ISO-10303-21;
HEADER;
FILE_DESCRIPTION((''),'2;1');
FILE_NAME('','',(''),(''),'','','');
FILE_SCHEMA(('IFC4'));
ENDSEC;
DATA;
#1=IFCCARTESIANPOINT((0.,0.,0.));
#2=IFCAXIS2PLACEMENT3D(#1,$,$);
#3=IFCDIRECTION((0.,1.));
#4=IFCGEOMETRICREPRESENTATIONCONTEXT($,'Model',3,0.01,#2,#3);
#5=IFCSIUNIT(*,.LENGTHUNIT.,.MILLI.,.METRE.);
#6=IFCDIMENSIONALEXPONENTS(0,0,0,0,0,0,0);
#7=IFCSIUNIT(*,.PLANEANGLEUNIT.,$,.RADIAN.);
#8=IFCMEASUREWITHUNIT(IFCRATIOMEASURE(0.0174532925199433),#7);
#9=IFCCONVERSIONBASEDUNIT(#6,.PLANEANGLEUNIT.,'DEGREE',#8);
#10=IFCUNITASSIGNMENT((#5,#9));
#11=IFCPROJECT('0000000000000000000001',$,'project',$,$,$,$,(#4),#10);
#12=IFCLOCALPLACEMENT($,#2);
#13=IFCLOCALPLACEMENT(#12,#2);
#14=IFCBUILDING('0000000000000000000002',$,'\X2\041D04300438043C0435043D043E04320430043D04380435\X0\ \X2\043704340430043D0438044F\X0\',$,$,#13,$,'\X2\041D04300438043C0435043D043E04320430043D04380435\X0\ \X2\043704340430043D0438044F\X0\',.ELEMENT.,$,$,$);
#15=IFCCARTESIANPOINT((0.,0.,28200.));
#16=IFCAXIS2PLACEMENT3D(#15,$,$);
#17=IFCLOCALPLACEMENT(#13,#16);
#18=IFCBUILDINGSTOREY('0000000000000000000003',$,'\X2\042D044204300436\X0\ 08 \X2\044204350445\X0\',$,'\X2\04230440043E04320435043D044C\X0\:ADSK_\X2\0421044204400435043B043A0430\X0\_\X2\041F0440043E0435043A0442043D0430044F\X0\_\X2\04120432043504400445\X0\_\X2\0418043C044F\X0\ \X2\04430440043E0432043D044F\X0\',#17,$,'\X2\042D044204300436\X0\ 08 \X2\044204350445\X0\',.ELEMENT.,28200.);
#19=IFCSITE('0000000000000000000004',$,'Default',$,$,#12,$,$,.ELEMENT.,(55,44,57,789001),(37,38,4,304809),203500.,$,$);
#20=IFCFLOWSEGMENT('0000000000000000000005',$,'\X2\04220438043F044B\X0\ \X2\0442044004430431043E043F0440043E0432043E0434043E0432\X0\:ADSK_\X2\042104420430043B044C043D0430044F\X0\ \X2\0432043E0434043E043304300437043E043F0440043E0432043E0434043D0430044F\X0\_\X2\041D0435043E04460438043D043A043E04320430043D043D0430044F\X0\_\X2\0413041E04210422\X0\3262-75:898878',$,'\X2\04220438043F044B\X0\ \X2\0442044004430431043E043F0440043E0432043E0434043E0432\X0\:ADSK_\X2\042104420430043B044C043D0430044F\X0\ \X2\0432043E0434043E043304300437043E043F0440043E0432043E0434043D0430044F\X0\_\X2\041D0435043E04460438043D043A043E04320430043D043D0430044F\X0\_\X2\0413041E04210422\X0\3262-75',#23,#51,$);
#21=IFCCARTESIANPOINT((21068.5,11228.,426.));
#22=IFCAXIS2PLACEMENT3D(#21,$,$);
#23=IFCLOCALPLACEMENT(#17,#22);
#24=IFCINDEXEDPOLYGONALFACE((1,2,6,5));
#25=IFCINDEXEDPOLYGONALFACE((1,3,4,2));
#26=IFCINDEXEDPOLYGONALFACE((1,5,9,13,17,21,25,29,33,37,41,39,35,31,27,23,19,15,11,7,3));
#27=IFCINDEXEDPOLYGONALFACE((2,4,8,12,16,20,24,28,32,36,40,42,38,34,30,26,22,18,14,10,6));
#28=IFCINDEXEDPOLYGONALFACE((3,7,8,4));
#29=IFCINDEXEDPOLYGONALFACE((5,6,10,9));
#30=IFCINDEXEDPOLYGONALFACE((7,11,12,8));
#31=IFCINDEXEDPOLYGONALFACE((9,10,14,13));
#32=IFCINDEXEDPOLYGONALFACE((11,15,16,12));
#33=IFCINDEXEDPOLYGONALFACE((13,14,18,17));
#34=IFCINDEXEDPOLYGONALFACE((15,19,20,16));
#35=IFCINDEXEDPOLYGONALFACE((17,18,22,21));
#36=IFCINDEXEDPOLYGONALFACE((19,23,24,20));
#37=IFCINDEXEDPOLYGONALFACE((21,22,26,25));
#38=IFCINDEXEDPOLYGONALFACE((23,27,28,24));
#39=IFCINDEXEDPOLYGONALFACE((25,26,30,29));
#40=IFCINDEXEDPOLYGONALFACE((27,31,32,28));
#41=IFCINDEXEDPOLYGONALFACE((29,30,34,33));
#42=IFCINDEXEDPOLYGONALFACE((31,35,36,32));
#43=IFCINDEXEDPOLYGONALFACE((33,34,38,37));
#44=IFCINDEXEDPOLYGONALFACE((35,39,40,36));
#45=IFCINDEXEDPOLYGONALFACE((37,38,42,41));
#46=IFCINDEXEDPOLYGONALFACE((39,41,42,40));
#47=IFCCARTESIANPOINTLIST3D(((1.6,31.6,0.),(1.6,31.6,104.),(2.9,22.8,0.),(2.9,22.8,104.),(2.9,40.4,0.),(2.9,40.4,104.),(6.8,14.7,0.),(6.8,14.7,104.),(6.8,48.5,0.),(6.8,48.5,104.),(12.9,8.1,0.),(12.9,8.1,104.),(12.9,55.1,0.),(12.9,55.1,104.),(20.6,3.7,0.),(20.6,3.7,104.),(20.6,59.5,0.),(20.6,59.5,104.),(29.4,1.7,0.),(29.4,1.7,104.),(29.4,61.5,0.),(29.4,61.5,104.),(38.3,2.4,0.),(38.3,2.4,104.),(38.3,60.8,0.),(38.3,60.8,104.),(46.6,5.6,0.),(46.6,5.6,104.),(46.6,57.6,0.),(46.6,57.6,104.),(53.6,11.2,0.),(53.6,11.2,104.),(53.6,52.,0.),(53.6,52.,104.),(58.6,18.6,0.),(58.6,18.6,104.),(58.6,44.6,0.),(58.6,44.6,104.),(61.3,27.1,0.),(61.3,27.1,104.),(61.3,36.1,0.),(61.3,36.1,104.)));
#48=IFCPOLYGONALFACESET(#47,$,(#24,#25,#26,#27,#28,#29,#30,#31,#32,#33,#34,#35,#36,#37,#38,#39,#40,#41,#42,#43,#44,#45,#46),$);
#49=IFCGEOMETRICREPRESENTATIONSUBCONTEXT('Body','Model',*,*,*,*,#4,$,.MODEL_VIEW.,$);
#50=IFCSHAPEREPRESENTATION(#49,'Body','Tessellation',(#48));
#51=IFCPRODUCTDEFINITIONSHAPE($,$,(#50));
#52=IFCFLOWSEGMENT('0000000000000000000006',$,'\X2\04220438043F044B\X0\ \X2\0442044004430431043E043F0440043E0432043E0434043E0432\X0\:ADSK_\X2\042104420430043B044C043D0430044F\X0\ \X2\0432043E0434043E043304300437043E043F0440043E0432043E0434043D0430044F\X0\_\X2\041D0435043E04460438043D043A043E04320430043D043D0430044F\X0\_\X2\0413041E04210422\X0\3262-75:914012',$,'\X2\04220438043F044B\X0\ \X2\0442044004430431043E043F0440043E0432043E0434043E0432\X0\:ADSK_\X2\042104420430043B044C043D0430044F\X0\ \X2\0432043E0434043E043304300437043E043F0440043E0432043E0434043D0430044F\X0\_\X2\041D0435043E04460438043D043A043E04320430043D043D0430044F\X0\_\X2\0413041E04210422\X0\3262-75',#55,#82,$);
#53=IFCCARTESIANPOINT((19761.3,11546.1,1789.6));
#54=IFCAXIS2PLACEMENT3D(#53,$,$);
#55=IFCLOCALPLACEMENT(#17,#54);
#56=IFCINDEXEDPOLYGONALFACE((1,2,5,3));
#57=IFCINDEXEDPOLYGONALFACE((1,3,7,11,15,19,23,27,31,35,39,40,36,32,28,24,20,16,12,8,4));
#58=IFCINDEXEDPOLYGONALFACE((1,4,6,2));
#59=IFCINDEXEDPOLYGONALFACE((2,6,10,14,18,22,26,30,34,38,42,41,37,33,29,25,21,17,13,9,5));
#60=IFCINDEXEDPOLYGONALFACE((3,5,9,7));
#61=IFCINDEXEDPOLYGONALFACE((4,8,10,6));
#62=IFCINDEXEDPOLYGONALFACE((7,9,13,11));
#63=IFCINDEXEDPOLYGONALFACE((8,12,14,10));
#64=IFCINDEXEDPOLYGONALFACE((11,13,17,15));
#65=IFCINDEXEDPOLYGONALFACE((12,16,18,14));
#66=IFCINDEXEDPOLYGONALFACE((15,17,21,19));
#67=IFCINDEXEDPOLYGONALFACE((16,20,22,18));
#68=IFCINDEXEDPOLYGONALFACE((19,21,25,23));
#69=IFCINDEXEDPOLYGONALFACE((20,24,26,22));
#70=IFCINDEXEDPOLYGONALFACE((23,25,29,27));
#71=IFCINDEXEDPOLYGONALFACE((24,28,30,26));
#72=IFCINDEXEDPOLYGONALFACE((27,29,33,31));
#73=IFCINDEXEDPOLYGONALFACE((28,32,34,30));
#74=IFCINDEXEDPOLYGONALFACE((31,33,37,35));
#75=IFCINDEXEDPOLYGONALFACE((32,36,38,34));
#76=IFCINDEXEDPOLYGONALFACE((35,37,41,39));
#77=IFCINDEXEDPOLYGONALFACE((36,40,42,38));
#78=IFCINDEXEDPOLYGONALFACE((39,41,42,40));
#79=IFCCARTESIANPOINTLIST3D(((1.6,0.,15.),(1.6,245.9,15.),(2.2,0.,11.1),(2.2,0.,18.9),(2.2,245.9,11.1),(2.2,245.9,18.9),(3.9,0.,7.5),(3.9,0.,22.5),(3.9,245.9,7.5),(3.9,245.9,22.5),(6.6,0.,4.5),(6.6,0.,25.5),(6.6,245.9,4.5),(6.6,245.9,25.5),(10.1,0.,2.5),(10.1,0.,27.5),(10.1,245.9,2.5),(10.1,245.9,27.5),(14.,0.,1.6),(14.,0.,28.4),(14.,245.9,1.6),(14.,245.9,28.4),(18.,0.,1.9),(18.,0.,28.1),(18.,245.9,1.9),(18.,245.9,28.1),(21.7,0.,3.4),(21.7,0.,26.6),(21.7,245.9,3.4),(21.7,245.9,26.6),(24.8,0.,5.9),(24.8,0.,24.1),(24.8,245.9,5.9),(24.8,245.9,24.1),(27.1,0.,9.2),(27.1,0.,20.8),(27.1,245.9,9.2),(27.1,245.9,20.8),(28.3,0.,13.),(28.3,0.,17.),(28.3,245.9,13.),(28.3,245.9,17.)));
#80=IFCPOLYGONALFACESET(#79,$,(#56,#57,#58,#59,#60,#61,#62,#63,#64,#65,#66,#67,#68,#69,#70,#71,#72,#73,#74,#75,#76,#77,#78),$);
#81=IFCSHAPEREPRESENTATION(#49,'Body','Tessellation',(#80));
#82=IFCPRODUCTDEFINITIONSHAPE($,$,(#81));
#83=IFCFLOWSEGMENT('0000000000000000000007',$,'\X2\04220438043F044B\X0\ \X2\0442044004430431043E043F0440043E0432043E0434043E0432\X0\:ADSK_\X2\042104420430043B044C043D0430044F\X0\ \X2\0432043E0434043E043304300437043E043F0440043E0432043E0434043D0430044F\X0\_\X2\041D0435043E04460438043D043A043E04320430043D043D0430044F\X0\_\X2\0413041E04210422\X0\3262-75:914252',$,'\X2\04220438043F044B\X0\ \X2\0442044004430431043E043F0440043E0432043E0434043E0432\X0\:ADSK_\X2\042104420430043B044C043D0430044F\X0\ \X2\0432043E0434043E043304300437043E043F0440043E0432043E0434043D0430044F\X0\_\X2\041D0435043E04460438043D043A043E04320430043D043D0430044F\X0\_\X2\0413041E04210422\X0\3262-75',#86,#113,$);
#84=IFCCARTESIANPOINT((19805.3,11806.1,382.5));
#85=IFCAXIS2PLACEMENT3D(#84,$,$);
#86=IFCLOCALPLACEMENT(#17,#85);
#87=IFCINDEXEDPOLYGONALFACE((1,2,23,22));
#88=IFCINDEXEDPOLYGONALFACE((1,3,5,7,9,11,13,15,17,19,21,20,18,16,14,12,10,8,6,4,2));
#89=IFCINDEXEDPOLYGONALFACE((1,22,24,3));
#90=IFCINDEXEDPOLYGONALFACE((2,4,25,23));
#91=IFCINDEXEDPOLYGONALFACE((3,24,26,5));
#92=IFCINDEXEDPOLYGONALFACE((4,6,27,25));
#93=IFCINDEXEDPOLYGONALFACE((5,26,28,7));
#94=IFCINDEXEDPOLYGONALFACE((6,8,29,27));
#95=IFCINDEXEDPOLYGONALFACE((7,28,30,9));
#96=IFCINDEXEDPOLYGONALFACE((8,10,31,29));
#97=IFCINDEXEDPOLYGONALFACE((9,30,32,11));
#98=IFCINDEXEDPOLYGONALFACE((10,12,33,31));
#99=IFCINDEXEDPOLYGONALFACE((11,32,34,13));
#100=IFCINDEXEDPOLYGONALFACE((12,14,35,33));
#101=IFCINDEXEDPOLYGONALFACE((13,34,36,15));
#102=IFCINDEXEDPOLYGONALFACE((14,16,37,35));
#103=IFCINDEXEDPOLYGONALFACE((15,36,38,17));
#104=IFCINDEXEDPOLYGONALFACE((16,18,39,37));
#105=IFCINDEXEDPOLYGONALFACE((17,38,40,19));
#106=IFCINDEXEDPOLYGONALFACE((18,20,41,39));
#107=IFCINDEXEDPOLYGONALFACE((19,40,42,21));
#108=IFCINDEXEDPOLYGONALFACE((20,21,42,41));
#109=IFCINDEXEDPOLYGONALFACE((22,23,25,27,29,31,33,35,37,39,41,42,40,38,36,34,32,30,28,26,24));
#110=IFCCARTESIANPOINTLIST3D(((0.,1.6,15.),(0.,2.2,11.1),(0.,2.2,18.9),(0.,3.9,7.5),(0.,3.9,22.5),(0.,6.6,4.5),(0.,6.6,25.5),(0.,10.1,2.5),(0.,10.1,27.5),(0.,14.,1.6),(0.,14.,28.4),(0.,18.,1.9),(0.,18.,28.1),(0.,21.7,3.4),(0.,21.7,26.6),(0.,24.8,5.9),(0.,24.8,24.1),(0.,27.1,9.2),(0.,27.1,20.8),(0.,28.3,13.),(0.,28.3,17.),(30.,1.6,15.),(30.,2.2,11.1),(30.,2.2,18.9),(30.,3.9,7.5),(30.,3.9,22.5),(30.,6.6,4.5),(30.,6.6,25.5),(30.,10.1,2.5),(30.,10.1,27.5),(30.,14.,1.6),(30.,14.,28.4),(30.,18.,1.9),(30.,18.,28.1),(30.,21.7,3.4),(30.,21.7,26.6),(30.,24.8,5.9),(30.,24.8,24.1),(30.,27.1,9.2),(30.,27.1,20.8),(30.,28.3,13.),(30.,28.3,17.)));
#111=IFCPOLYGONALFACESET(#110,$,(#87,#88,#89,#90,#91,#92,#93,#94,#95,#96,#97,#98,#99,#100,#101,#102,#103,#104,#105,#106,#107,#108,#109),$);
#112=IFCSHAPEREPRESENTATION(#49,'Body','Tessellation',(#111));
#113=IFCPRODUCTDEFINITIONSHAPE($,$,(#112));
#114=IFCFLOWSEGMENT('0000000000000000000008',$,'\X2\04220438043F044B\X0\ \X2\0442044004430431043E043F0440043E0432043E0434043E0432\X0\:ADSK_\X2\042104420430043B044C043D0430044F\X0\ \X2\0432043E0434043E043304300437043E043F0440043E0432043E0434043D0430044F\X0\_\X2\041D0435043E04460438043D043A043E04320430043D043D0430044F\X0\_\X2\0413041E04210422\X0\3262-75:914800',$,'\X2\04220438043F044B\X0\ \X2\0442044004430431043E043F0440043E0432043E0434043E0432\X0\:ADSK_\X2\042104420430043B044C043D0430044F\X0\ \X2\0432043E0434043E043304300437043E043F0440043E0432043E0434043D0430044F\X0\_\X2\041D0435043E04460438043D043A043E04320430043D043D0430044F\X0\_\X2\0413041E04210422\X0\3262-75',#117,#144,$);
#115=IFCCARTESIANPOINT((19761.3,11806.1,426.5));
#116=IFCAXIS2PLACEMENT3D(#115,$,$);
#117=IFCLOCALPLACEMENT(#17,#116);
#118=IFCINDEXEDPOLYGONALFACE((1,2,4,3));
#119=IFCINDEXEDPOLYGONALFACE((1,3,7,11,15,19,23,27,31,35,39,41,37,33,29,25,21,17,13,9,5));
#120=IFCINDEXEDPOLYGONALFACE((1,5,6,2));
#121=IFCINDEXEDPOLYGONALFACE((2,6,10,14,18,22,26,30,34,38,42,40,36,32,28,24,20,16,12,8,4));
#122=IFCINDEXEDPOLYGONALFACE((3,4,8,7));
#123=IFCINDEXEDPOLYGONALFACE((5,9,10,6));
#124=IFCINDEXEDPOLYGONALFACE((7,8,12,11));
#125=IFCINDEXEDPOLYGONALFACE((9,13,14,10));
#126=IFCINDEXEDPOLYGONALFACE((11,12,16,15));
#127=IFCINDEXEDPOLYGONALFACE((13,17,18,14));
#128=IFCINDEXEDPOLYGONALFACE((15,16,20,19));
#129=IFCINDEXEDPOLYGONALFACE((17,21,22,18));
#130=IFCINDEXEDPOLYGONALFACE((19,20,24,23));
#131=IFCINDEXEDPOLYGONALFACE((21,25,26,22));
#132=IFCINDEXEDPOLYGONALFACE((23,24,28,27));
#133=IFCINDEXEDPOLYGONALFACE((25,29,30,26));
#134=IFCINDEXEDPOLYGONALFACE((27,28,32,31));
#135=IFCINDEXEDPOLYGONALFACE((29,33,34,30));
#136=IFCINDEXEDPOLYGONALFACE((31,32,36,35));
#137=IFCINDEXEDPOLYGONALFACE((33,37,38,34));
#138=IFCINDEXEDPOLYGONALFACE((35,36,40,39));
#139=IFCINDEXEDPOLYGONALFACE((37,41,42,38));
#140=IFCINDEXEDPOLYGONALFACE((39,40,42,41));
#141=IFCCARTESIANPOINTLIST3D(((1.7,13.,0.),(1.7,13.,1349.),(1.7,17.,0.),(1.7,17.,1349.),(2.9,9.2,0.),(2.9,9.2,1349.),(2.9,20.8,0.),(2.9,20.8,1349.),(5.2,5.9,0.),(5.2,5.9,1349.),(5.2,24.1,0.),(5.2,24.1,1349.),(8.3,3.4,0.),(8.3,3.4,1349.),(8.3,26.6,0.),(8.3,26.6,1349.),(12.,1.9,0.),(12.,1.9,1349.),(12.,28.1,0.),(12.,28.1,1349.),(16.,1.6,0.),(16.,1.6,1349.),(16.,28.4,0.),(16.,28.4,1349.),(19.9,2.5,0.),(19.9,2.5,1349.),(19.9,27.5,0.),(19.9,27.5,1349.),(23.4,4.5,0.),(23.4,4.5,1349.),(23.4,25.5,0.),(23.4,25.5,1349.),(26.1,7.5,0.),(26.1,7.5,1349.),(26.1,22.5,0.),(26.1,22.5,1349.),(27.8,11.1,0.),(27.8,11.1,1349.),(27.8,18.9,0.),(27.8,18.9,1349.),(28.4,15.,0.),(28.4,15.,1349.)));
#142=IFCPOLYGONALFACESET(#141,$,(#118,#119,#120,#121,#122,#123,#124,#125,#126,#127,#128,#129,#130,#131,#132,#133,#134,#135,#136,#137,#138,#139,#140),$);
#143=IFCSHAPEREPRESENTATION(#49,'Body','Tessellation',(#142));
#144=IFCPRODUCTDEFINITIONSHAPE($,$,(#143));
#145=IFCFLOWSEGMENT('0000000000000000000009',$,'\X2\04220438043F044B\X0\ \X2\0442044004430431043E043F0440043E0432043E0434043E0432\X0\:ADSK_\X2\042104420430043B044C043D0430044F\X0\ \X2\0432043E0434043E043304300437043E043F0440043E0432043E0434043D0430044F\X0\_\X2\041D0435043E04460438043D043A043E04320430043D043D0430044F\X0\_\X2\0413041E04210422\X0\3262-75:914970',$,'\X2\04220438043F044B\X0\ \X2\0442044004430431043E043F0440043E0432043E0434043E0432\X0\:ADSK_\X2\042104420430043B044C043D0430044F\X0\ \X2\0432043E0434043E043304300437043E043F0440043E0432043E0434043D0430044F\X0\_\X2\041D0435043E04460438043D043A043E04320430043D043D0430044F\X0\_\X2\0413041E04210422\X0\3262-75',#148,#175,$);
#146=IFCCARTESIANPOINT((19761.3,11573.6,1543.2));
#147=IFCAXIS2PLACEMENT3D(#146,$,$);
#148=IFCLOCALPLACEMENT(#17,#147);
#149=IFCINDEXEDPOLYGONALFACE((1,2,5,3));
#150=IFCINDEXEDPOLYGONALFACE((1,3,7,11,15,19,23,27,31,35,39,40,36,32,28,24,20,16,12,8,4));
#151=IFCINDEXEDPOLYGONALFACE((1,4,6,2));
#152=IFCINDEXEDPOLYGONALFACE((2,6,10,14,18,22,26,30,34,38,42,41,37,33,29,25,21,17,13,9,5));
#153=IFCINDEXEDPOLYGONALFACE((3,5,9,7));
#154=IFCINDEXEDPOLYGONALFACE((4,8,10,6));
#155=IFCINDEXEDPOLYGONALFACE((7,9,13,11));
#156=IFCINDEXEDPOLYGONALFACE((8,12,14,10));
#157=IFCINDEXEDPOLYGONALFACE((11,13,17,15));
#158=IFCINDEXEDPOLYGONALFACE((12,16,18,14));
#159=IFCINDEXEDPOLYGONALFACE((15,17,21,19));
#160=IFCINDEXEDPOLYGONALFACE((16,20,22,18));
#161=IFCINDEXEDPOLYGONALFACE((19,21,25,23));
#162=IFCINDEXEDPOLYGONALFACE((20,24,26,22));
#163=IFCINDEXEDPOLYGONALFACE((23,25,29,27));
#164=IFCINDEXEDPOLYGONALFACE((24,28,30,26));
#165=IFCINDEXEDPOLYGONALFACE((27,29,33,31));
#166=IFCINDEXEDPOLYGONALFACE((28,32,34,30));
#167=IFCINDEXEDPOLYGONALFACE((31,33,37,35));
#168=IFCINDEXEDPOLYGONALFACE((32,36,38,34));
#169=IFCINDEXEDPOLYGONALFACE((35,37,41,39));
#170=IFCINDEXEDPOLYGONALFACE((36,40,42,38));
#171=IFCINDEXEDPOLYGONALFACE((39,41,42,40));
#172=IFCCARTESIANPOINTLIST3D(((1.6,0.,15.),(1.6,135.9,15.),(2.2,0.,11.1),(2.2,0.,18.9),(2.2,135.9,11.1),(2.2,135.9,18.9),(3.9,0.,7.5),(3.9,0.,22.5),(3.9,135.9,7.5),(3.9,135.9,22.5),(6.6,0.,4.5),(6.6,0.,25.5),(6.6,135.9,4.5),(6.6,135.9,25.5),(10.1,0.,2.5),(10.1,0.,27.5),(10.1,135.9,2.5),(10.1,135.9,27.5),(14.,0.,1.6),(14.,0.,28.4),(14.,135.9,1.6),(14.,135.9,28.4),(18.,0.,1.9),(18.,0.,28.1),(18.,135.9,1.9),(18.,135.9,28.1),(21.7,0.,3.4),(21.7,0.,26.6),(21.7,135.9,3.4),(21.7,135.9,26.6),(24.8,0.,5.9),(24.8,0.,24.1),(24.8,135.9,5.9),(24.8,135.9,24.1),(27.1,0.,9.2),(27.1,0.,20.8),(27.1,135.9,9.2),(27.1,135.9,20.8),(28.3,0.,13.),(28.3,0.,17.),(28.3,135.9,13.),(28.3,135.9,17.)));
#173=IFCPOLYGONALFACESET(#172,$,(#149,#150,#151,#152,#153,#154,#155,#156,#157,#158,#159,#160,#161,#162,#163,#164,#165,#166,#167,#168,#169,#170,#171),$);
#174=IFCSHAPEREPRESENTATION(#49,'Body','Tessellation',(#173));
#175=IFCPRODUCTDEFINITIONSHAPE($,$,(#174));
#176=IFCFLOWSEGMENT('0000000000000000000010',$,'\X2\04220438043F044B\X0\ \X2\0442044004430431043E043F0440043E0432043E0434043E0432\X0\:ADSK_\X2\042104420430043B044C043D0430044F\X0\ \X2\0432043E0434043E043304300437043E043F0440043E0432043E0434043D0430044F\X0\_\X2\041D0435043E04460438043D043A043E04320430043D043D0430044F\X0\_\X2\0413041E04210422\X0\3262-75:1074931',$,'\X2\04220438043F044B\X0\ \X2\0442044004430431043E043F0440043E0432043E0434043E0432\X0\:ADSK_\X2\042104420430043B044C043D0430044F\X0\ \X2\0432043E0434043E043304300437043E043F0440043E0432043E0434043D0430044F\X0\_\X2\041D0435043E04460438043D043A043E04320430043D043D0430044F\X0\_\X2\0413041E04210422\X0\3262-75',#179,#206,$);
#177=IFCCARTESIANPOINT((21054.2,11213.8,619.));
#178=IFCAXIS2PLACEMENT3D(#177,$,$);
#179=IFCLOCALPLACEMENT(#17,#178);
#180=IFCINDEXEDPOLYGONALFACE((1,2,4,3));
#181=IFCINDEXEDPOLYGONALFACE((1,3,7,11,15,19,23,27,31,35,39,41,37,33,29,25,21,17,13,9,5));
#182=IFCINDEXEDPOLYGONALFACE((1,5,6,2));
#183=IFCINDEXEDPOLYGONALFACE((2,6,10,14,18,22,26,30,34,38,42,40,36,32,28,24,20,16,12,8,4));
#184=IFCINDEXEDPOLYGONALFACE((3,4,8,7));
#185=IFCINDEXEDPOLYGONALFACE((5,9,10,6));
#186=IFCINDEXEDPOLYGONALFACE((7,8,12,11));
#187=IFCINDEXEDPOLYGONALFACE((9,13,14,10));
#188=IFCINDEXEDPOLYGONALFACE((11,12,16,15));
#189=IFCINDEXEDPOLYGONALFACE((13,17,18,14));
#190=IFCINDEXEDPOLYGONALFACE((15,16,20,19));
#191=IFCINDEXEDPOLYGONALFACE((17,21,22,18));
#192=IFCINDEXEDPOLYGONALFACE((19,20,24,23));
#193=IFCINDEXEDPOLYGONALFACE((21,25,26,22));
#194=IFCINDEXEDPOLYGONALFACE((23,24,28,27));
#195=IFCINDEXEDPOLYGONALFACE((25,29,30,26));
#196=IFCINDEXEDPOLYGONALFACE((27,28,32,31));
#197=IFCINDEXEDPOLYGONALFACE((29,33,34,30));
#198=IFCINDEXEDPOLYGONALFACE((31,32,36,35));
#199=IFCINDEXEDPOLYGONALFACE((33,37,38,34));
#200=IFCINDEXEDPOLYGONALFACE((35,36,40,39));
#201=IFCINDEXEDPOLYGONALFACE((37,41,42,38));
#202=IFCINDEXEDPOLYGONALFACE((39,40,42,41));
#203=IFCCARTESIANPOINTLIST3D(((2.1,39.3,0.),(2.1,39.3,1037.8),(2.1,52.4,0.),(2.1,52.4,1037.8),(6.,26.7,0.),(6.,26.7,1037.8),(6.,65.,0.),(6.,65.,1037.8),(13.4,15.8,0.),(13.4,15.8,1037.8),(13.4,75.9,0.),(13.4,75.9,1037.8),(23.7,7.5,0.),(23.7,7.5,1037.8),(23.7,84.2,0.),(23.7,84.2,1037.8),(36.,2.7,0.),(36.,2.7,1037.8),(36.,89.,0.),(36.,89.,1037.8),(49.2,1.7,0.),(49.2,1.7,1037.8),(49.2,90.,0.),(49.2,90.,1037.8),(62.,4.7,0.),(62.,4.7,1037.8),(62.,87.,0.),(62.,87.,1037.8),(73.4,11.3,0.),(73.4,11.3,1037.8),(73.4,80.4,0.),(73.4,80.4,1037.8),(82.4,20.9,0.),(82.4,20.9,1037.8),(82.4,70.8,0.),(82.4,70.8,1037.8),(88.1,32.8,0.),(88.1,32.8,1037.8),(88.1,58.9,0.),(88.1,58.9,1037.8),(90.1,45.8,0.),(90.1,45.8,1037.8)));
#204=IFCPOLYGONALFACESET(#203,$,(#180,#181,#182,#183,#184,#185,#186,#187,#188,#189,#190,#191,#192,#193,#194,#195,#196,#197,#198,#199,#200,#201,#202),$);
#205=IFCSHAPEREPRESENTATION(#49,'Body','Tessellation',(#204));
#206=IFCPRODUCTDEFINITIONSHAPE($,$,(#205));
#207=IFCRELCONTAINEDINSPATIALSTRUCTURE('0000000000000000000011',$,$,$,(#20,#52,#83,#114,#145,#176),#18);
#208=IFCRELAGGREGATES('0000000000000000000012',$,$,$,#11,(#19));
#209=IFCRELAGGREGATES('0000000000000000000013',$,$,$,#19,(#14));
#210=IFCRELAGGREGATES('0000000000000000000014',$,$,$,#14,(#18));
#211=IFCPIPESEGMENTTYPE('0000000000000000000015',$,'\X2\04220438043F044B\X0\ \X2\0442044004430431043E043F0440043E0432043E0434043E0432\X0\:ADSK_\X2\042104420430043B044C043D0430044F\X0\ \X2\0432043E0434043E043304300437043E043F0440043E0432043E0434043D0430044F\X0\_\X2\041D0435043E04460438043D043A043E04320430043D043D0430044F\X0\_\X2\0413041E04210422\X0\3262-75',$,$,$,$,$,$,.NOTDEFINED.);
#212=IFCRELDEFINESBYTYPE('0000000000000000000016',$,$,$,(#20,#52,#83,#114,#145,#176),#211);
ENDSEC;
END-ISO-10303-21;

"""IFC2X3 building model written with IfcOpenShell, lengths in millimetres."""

from ifc_helpers import new_model, entity, si_unit, converted_unit, direction, frame, origin, origin_2d_with_axis, place, context, subcontext, project, spatial, circle, extrude, type_object, element, save


model = new_model("IFC2X3")

# Units and contexts
model_context = context("Model", 3, precision=0.01, world=origin(), true_north=direction((0.0, 1.0)))
body_context = subcontext(model_context, "Body", "Model", "MODEL_VIEW")
ifc_project = project(units=[si_unit("LENGTHUNIT", "METRE", prefix="MILLI"), converted_unit("PLANEANGLEUNIT", "DEGREE", entity("IfcRatioMeasure", 0.0174532925199433), si_unit("PLANEANGLEUNIT", "RADIAN"), dimensions=[0, 0, 0, 0, 0, 0, 0])], contexts=[model_context])

# Site, building, storey
site_placement = place(None, origin())
site = spatial("IfcSite", under=ifc_project, at=site_placement, Name="Default", CompositionType="ELEMENT", RefLatitude=(55, 44, 57, 789001), RefLongitude=(37, 38, 4, 304809), RefElevation=203500.0)
building_placement = place(site_placement, origin())
building = spatial("IfcBuilding", under=site, at=building_placement, Name="Наименование здания", LongName="Наименование здания", CompositionType="ELEMENT")
storey_placement = place(building_placement, frame((0.0, 0.0, 28200.0)))
storey = spatial("IfcBuildingStorey", under=building, at=storey_placement, Name="Этаж 08 тех", ObjectType="Уровень:ADSK_Стрелка_Проектная_Вверх_Имя уровня", LongName="Этаж 08 тех", CompositionType="ELEMENT", Elevation=28200.0)

# Flow segments
pipe_segment_type = type_object("IfcPipeSegmentType", Name="Типы трубопроводов:ADSK_Стальная водогазопроводная_Неоцинкованная_ГОСТ3262-75", PredefinedType="NOTDEFINED")
flow_segment_1_placement = place(storey_placement, frame((21068.5, 11228.0, 426.0)))
element("IfcFlowSegment", 1, at=flow_segment_1_placement, inside=storey, type_object=pipe_segment_type, Name="Типы трубопроводов:ADSK_Стальная водогазопроводная_Неоцинкованная_ГОСТ3262-75:898878", ObjectType="Типы трубопроводов:ADSK_Стальная водогазопроводная_Неоцинкованная_ГОСТ3262-75", context=body_context, shape_type="SweptSolid", body=[
    extrude(circle(Radius=30.0, at=origin_2d_with_axis()), frame((31.6, 31.6, 0.0), z_axis=(0.0, 0.0, 1.0), x_axis=(-1.0, 0.0, 0.0)), (0.0, 0.0, 1.0), 104.0),
])
flow_segment_2_placement = place(storey_placement, frame((19761.3, 11546.1, 1789.6)))
element("IfcFlowSegment", 2, at=flow_segment_2_placement, inside=storey, type_object=pipe_segment_type, Name="Типы трубопроводов:ADSK_Стальная водогазопроводная_Неоцинкованная_ГОСТ3262-75:914012", ObjectType="Типы трубопроводов:ADSK_Стальная водогазопроводная_Неоцинкованная_ГОСТ3262-75", context=body_context, shape_type="SweptSolid", body=[
    extrude(circle(Radius=13.4, at=origin_2d_with_axis()), frame((15.0, 0.0, 15.0), z_axis=(0.0, 1.0, 0.0), x_axis=(-1.0, 0.0, 0.0)), (0.0, 0.0, 1.0), 245.9),
])
flow_segment_3_placement = place(storey_placement, frame((19805.3, 11806.1, 382.5)))
element("IfcFlowSegment", 3, at=flow_segment_3_placement, inside=storey, type_object=pipe_segment_type, Name="Типы трубопроводов:ADSK_Стальная водогазопроводная_Неоцинкованная_ГОСТ3262-75:914252", ObjectType="Типы трубопроводов:ADSK_Стальная водогазопроводная_Неоцинкованная_ГОСТ3262-75", context=body_context, shape_type="SweptSolid", body=[
    extrude(circle(Radius=13.4, at=origin_2d_with_axis()), frame((0.0, 15.0, 15.0), z_axis=(1.0, 0.0, 0.0), x_axis=(0.0, -1.0, 0.0)), (0.0, 0.0, 1.0), 30.0),
])
flow_segment_4_placement = place(storey_placement, frame((19761.3, 11806.1, 426.5)))
element("IfcFlowSegment", 4, at=flow_segment_4_placement, inside=storey, type_object=pipe_segment_type, Name="Типы трубопроводов:ADSK_Стальная водогазопроводная_Неоцинкованная_ГОСТ3262-75:914800", ObjectType="Типы трубопроводов:ADSK_Стальная водогазопроводная_Неоцинкованная_ГОСТ3262-75", context=body_context, shape_type="SweptSolid", body=[
    extrude(circle(Radius=13.4, at=origin_2d_with_axis()), frame((15.0, 15.0, 0.0)), (0.0, 0.0, 1.0), 1349.0),
])
flow_segment_5_placement = place(storey_placement, frame((19761.3, 11573.6, 1543.2)))
element("IfcFlowSegment", 5, at=flow_segment_5_placement, inside=storey, type_object=pipe_segment_type, Name="Типы трубопроводов:ADSK_Стальная водогазопроводная_Неоцинкованная_ГОСТ3262-75:914970", ObjectType="Типы трубопроводов:ADSK_Стальная водогазопроводная_Неоцинкованная_ГОСТ3262-75", context=body_context, shape_type="SweptSolid", body=[
    extrude(circle(Radius=13.4, at=origin_2d_with_axis()), frame((15.0, 0.0, 15.0), z_axis=(0.0, 1.0, 0.0), x_axis=(-1.0, 0.0, 0.0)), (0.0, 0.0, 1.0), 135.9),
])
flow_segment_6_placement = place(storey_placement, frame((21054.2, 11213.8, 619.0)))
element("IfcFlowSegment", 6, at=flow_segment_6_placement, inside=storey, type_object=pipe_segment_type, Name="Типы трубопроводов:ADSK_Стальная водогазопроводная_Неоцинкованная_ГОСТ3262-75:1074931", ObjectType="Типы трубопроводов:ADSK_Стальная водогазопроводная_Неоцинкованная_ГОСТ3262-75", context=body_context, shape_type="SweptSolid", body=[
    extrude(circle(Radius=44.2, at=origin_2d_with_axis()), frame((45.9, 45.9, 0.0)), (0.0, 0.0, 1.0), 1037.8),
])

save(model, "model.ifc")
